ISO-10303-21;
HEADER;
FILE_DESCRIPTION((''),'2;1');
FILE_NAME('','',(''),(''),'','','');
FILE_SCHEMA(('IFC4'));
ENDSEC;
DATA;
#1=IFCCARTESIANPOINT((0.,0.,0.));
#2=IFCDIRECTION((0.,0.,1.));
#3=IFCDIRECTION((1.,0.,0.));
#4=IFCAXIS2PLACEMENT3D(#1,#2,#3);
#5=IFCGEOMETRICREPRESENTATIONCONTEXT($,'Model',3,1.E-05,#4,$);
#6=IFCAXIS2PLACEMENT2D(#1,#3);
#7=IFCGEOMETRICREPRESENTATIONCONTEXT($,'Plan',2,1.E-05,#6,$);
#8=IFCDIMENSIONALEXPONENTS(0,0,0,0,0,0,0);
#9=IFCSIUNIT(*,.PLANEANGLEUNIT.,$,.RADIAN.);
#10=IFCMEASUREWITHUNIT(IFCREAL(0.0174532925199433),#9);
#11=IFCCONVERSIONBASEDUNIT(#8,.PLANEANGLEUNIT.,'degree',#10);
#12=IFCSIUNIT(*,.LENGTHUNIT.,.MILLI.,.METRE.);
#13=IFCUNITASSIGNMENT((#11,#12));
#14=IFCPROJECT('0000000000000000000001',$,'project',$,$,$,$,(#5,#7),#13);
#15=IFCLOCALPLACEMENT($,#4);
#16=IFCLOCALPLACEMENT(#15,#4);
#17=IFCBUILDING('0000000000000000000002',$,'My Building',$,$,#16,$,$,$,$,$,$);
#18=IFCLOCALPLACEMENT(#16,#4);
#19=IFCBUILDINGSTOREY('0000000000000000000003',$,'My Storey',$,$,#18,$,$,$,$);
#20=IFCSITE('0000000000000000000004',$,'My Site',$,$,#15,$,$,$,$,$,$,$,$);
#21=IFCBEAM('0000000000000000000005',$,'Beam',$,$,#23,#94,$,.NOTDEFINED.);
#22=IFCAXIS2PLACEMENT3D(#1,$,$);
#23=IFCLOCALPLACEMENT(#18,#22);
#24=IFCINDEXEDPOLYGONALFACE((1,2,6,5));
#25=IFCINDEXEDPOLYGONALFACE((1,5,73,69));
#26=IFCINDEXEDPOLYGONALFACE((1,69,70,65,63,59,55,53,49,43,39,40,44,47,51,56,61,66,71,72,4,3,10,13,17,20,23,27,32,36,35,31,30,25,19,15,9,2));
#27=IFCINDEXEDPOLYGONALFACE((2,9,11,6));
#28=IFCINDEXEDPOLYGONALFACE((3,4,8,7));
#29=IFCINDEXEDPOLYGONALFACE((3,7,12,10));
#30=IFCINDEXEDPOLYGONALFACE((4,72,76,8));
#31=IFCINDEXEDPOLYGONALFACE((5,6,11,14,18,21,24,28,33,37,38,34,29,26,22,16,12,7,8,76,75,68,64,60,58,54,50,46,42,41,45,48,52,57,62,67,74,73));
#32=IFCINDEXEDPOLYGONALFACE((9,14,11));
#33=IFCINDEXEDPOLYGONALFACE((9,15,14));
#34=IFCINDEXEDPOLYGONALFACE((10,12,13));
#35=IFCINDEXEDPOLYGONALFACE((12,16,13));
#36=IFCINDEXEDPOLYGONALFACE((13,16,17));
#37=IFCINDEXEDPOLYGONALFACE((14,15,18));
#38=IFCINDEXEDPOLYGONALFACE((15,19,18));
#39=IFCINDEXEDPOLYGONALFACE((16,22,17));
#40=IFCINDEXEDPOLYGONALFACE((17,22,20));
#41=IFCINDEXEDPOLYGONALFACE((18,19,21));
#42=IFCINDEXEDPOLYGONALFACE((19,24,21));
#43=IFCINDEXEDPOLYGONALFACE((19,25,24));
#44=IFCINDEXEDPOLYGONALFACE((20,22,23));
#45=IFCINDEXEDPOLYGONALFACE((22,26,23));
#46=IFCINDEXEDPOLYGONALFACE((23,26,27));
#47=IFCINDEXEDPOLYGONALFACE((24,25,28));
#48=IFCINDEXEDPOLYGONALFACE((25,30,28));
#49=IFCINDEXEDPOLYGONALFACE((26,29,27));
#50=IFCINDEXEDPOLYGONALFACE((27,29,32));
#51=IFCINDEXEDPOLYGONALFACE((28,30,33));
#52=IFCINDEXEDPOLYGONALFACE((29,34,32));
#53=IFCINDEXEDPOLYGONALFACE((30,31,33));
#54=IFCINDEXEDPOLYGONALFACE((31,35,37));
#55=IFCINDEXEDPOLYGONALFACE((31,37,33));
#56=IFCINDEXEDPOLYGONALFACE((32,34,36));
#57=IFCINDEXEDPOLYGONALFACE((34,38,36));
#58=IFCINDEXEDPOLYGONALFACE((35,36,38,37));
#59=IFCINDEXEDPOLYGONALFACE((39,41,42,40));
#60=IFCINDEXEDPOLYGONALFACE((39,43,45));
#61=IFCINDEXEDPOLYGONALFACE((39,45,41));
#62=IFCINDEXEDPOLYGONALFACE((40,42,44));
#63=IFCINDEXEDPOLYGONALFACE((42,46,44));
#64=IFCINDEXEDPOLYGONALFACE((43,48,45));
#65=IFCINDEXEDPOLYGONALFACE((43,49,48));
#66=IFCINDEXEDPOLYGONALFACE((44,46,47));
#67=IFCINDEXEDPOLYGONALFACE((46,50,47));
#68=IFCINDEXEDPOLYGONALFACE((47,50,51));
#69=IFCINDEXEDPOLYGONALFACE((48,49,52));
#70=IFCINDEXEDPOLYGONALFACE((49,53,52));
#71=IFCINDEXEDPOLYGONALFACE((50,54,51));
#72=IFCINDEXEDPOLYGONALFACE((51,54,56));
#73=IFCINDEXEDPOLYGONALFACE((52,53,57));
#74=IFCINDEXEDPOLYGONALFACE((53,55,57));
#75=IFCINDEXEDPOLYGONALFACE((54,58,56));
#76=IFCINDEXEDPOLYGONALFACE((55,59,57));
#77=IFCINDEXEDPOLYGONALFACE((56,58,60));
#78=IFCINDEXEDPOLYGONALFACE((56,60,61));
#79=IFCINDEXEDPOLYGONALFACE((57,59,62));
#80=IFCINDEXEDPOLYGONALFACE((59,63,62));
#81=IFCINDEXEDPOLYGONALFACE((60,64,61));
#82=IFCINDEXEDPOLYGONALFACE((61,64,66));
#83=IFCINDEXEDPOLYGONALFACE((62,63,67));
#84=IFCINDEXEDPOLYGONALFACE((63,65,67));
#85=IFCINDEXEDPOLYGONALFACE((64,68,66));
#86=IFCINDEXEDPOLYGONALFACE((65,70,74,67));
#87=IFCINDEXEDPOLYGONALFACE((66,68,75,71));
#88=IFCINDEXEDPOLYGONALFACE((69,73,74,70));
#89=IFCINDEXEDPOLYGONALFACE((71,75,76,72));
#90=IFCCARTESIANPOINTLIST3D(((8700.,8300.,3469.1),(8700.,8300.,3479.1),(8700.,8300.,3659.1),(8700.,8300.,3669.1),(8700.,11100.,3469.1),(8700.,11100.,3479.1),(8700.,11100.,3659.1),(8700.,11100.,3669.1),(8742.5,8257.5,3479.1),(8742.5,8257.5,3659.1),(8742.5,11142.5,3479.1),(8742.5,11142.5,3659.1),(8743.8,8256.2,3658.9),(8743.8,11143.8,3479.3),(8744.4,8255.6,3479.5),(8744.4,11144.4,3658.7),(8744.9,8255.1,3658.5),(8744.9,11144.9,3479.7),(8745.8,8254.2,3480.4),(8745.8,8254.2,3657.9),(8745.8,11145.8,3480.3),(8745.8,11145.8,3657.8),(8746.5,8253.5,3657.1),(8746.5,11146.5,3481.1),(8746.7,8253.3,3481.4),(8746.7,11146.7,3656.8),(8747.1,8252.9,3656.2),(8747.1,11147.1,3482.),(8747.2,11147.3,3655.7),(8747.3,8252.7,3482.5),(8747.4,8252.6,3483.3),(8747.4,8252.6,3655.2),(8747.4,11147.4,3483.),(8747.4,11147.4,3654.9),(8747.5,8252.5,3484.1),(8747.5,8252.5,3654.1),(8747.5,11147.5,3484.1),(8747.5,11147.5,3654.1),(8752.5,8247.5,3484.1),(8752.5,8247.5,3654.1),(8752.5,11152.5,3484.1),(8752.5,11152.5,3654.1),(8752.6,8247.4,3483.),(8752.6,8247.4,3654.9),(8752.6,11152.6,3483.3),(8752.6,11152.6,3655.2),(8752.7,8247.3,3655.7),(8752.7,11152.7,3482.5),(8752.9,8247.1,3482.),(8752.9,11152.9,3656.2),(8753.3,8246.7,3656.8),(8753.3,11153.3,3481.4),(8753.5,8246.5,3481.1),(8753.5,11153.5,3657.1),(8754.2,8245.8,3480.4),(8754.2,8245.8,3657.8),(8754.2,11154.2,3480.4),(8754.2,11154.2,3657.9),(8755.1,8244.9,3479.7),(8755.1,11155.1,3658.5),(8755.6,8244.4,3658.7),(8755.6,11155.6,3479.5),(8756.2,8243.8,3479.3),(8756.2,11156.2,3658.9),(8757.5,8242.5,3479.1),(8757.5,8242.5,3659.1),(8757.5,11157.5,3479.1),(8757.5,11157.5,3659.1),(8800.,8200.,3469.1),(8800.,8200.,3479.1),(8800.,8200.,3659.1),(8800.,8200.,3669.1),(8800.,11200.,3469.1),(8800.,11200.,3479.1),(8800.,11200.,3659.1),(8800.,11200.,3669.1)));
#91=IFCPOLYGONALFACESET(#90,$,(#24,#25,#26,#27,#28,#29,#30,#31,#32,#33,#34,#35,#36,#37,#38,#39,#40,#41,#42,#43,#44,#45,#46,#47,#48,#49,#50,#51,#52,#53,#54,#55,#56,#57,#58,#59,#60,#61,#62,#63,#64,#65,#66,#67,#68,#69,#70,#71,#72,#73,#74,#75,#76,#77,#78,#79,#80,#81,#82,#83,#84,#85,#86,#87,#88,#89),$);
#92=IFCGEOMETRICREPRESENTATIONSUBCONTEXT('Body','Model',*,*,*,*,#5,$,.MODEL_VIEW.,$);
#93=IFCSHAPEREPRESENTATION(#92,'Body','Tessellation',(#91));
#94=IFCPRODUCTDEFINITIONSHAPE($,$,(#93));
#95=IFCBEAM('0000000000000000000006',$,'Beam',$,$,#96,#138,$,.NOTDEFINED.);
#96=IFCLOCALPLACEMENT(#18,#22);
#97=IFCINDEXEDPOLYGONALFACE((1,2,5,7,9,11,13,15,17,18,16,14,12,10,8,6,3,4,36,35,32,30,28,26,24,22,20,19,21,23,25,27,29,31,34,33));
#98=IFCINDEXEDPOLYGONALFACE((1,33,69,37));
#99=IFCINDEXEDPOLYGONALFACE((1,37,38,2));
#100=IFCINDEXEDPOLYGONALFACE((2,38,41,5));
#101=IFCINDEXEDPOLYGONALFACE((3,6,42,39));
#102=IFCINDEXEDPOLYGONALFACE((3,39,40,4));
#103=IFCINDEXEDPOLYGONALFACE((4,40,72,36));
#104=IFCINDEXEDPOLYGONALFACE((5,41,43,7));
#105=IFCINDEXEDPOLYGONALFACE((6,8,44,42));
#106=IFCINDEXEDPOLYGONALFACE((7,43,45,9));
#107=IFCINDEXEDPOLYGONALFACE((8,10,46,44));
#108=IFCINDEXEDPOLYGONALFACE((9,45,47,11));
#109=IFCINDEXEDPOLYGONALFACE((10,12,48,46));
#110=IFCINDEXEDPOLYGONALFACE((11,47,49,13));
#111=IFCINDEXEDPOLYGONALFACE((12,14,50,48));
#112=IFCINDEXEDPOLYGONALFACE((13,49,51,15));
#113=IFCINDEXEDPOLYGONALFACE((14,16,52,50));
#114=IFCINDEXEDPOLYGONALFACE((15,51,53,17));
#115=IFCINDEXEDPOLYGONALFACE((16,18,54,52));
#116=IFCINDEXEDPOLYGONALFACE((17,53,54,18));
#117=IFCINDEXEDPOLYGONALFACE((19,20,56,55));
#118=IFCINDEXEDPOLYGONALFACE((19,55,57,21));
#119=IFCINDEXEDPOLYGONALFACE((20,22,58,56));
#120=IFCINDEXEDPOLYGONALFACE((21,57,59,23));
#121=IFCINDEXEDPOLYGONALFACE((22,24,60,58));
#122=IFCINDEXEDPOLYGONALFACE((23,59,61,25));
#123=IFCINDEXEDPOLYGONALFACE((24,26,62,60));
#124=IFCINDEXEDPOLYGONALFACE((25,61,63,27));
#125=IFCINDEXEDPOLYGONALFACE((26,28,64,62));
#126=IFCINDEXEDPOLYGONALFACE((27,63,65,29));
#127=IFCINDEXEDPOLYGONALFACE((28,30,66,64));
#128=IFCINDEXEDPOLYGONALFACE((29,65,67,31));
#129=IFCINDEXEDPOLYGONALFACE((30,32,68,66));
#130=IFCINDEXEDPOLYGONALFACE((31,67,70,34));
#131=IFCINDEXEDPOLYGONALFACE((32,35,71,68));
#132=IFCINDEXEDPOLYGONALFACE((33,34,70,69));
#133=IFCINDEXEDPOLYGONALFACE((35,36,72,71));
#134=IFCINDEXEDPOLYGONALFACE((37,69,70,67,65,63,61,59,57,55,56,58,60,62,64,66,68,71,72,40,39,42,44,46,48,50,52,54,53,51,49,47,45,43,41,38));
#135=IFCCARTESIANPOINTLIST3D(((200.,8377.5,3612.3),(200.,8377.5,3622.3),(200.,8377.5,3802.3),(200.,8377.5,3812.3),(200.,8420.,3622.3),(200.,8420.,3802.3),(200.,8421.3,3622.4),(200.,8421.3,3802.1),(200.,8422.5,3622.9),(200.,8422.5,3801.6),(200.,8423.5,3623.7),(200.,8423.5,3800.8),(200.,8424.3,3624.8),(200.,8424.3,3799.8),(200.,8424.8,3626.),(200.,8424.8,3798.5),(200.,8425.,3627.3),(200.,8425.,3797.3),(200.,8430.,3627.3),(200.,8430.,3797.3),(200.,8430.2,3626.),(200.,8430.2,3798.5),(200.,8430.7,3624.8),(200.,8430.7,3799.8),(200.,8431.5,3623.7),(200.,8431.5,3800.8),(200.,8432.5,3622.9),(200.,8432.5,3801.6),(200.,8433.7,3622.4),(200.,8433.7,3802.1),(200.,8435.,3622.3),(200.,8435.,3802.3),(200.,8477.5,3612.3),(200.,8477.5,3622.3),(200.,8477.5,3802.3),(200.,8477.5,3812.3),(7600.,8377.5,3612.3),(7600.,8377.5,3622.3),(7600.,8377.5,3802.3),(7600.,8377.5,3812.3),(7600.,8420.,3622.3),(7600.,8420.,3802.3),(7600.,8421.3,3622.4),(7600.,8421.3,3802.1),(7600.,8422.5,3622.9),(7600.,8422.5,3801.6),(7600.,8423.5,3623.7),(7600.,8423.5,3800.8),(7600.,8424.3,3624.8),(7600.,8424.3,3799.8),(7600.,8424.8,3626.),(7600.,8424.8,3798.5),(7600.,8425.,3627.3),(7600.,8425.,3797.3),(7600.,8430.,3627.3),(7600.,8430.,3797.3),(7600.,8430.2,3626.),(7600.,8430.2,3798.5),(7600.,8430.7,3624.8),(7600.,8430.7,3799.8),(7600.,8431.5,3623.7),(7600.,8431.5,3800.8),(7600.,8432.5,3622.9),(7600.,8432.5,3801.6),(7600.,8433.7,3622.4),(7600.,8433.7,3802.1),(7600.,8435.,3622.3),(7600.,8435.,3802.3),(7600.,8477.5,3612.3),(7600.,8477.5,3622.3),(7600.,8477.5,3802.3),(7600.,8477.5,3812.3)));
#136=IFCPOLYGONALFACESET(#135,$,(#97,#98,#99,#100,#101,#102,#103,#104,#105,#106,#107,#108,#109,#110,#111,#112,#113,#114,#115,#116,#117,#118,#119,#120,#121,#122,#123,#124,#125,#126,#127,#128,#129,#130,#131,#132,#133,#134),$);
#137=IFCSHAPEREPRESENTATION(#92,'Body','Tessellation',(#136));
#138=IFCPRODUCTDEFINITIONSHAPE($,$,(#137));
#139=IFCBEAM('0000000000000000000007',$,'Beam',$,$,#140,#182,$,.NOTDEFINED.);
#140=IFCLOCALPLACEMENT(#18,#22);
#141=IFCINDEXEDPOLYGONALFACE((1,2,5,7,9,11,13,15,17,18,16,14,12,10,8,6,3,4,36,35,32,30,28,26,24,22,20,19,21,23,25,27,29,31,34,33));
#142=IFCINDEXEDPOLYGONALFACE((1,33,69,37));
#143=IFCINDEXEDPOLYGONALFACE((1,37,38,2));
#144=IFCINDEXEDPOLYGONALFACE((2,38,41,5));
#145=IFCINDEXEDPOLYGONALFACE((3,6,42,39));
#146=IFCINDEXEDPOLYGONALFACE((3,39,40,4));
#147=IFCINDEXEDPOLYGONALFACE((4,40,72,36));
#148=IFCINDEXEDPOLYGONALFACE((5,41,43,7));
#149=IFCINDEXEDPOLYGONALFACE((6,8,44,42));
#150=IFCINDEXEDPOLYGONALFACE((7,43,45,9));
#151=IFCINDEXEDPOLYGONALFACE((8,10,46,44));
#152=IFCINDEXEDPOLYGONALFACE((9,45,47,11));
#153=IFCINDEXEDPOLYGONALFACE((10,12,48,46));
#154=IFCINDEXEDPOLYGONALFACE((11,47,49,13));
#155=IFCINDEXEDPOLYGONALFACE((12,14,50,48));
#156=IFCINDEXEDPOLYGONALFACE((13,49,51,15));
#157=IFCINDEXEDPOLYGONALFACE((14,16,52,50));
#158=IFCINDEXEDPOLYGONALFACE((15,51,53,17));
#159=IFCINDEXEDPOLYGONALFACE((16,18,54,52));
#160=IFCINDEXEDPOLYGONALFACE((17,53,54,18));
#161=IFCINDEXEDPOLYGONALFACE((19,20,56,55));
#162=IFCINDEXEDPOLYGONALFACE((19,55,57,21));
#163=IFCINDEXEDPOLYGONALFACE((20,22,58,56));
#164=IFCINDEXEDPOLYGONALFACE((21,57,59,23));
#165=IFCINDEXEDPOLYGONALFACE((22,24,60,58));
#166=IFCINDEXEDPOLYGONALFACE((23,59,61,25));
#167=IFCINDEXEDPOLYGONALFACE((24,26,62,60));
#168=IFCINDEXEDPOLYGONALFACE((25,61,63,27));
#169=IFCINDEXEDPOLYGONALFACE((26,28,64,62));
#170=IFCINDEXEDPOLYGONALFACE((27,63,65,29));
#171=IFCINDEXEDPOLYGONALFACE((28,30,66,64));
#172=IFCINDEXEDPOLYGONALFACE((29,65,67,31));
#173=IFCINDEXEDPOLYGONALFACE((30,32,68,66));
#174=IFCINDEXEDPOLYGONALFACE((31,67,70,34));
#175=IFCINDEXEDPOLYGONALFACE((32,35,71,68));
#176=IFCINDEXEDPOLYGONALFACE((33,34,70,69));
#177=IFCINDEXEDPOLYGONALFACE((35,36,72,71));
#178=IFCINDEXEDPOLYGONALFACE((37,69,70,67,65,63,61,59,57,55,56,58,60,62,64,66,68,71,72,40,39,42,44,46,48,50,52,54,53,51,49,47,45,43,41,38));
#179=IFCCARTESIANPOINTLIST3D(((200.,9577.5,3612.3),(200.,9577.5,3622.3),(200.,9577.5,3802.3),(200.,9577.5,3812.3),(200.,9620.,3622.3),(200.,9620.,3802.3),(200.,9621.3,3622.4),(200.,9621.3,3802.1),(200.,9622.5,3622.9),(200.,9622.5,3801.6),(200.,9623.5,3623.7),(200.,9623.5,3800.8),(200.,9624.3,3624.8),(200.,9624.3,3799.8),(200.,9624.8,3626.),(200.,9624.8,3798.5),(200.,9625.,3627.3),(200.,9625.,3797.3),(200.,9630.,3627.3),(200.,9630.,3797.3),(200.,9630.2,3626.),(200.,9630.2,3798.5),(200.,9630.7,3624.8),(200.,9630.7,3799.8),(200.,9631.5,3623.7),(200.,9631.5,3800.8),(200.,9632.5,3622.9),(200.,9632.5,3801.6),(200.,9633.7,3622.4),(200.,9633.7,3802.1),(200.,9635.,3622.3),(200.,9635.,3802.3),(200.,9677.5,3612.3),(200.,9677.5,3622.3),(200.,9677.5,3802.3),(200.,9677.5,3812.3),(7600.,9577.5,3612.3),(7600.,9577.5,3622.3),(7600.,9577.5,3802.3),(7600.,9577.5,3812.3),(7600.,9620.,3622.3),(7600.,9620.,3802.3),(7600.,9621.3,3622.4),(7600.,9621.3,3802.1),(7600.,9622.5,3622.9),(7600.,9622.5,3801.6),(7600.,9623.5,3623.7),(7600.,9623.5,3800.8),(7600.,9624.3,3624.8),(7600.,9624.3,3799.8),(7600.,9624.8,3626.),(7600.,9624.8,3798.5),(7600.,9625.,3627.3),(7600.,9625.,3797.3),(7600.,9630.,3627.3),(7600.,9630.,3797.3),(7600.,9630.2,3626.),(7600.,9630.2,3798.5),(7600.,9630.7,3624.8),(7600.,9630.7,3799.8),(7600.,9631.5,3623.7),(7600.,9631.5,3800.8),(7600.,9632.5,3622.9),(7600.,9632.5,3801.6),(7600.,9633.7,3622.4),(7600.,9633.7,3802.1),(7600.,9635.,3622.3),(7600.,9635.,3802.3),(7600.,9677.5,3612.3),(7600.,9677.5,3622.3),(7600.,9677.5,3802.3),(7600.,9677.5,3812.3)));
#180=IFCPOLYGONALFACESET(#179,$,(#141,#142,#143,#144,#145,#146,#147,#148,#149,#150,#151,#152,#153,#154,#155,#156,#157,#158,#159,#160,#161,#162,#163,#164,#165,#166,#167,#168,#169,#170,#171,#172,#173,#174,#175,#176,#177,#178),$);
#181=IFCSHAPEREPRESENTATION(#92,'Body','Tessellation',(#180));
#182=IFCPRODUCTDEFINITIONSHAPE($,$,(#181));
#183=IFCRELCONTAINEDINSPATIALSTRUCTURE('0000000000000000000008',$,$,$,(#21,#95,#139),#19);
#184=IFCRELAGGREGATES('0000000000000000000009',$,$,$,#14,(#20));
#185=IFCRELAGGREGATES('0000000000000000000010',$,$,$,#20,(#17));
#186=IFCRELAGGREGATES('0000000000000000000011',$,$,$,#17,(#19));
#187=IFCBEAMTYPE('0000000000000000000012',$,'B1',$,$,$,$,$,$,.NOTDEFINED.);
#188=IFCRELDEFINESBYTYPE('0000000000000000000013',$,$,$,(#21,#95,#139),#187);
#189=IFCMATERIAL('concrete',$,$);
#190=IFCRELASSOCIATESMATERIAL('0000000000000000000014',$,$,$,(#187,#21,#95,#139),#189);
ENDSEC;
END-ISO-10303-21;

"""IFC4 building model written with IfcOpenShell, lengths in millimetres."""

from ifc_helpers import new_model, entity, si_unit, converted_unit, frame, frame_2d, origin_with_axes, place, context, subcontext, project, spatial, i_section, extrude, clip, halfspace, material, material_profile, profile_set, profile_usage, type_object, element, save


model = new_model("IFC4")

# Units and contexts
model_context = context("Model", 3, precision=1e-05, world=origin_with_axes())
plan_context = context("Plan", 2, precision=1e-05, world=frame_2d((0.0, 0.0, 0.0), x_axis=(1.0, 0.0, 0.0)))
body_context = subcontext(model_context, "Body", "Model", "MODEL_VIEW")
ifc_project = project(units=[converted_unit("PLANEANGLEUNIT", "degree", entity("IfcReal", 0.0174532925199433), si_unit("PLANEANGLEUNIT", "RADIAN"), dimensions=[0, 0, 0, 0, 0, 0, 0]), si_unit("LENGTHUNIT", "METRE", prefix="MILLI")], contexts=[model_context, plan_context])

# Site, building, storey
site_placement = place(None, origin_with_axes())
site = spatial("IfcSite", under=ifc_project, at=site_placement, Name="My Site")
building_placement = place(site_placement, origin_with_axes())
building = spatial("IfcBuilding", under=site, at=building_placement, Name="My Building")
storey_placement = place(building_placement, origin_with_axes())
storey = spatial("IfcBuildingStorey", under=building, at=storey_placement, Name="My Storey")

# Beams
ifc_material = material(Name="concrete")
ifc_material_profile = material_profile(ifc_material, i_section(OverallWidth=100.0, OverallDepth=200.0, WebThickness=5.0, FlangeThickness=10.0, FilletRadius=5.0))
ifc_profile_set = profile_set([ifc_material_profile])
beam_type = type_object("IfcBeamType", Name="B1", PredefinedType="NOTDEFINED", material=ifc_profile_set)
ifc_profile_usage_1 = profile_usage(ifc_profile_set, cardinal=5)
beam_1_placement = place(storey_placement, frame((8750.0, 8200.0, 3569.1), z_axis=(0.0, 1.0, 0.0), x_axis=(-1.0, 0.0, 0.0)))
element("IfcBeam", 1, at=beam_1_placement, inside=storey, type_object=beam_type, material=ifc_profile_usage_1, Name="Beam", PredefinedType="NOTDEFINED", context=body_context, shape_type="Clipping", body=[
    clip(clip(extrude(i_section(OverallWidth=100.0, OverallDepth=200.0, WebThickness=5.0, FlangeThickness=10.0, FilletRadius=5.0), origin_with_axes(), (0.0, 0.0, 1.0), 3000.0), halfspace(frame((-50.0, -3569.1, 0.0), z_axis=(0.707107, 0.0, -0.707107), x_axis=(0.707107, 0.0, 0.707107)), False)), halfspace(frame((-50.0, -3569.1, 3000.0), z_axis=(0.707107, 0.0, 0.707107), x_axis=(0.707107, 0.0, -0.707107)), False)),
])
ifc_profile_usage_2 = profile_usage(ifc_profile_set, cardinal=5)
beam_2_placement = place(storey_placement, frame((200.0, 8427.5, 3712.3), z_axis=(1.0, 0.0, 0.0), x_axis=(0.0, 1.0, 0.0)))
element("IfcBeam", 2, at=beam_2_placement, inside=storey, type_object=beam_type, material=ifc_profile_usage_2, Name="Beam", PredefinedType="NOTDEFINED", context=body_context, shape_type="SweptSolid", body=[
    extrude(i_section(OverallWidth=100.0, OverallDepth=200.0, WebThickness=5.0, FlangeThickness=10.0, FilletRadius=5.0), origin_with_axes(), (0.0, 0.0, 1.0), 7400.0),
])
ifc_profile_usage_3 = profile_usage(ifc_profile_set, cardinal=5)
beam_3_placement = place(storey_placement, frame((200.0, 9627.5, 3712.3), z_axis=(1.0, 0.0, 0.0), x_axis=(0.0, 1.0, 0.0)))
element("IfcBeam", 3, at=beam_3_placement, inside=storey, type_object=beam_type, material=ifc_profile_usage_3, Name="Beam", PredefinedType="NOTDEFINED", context=body_context, shape_type="SweptSolid", body=[
    extrude(i_section(OverallWidth=100.0, OverallDepth=200.0, WebThickness=5.0, FlangeThickness=10.0, FilletRadius=5.0), origin_with_axes(), (0.0, 0.0, 1.0), 7400.0),
])

save(model, "model.ifc")
